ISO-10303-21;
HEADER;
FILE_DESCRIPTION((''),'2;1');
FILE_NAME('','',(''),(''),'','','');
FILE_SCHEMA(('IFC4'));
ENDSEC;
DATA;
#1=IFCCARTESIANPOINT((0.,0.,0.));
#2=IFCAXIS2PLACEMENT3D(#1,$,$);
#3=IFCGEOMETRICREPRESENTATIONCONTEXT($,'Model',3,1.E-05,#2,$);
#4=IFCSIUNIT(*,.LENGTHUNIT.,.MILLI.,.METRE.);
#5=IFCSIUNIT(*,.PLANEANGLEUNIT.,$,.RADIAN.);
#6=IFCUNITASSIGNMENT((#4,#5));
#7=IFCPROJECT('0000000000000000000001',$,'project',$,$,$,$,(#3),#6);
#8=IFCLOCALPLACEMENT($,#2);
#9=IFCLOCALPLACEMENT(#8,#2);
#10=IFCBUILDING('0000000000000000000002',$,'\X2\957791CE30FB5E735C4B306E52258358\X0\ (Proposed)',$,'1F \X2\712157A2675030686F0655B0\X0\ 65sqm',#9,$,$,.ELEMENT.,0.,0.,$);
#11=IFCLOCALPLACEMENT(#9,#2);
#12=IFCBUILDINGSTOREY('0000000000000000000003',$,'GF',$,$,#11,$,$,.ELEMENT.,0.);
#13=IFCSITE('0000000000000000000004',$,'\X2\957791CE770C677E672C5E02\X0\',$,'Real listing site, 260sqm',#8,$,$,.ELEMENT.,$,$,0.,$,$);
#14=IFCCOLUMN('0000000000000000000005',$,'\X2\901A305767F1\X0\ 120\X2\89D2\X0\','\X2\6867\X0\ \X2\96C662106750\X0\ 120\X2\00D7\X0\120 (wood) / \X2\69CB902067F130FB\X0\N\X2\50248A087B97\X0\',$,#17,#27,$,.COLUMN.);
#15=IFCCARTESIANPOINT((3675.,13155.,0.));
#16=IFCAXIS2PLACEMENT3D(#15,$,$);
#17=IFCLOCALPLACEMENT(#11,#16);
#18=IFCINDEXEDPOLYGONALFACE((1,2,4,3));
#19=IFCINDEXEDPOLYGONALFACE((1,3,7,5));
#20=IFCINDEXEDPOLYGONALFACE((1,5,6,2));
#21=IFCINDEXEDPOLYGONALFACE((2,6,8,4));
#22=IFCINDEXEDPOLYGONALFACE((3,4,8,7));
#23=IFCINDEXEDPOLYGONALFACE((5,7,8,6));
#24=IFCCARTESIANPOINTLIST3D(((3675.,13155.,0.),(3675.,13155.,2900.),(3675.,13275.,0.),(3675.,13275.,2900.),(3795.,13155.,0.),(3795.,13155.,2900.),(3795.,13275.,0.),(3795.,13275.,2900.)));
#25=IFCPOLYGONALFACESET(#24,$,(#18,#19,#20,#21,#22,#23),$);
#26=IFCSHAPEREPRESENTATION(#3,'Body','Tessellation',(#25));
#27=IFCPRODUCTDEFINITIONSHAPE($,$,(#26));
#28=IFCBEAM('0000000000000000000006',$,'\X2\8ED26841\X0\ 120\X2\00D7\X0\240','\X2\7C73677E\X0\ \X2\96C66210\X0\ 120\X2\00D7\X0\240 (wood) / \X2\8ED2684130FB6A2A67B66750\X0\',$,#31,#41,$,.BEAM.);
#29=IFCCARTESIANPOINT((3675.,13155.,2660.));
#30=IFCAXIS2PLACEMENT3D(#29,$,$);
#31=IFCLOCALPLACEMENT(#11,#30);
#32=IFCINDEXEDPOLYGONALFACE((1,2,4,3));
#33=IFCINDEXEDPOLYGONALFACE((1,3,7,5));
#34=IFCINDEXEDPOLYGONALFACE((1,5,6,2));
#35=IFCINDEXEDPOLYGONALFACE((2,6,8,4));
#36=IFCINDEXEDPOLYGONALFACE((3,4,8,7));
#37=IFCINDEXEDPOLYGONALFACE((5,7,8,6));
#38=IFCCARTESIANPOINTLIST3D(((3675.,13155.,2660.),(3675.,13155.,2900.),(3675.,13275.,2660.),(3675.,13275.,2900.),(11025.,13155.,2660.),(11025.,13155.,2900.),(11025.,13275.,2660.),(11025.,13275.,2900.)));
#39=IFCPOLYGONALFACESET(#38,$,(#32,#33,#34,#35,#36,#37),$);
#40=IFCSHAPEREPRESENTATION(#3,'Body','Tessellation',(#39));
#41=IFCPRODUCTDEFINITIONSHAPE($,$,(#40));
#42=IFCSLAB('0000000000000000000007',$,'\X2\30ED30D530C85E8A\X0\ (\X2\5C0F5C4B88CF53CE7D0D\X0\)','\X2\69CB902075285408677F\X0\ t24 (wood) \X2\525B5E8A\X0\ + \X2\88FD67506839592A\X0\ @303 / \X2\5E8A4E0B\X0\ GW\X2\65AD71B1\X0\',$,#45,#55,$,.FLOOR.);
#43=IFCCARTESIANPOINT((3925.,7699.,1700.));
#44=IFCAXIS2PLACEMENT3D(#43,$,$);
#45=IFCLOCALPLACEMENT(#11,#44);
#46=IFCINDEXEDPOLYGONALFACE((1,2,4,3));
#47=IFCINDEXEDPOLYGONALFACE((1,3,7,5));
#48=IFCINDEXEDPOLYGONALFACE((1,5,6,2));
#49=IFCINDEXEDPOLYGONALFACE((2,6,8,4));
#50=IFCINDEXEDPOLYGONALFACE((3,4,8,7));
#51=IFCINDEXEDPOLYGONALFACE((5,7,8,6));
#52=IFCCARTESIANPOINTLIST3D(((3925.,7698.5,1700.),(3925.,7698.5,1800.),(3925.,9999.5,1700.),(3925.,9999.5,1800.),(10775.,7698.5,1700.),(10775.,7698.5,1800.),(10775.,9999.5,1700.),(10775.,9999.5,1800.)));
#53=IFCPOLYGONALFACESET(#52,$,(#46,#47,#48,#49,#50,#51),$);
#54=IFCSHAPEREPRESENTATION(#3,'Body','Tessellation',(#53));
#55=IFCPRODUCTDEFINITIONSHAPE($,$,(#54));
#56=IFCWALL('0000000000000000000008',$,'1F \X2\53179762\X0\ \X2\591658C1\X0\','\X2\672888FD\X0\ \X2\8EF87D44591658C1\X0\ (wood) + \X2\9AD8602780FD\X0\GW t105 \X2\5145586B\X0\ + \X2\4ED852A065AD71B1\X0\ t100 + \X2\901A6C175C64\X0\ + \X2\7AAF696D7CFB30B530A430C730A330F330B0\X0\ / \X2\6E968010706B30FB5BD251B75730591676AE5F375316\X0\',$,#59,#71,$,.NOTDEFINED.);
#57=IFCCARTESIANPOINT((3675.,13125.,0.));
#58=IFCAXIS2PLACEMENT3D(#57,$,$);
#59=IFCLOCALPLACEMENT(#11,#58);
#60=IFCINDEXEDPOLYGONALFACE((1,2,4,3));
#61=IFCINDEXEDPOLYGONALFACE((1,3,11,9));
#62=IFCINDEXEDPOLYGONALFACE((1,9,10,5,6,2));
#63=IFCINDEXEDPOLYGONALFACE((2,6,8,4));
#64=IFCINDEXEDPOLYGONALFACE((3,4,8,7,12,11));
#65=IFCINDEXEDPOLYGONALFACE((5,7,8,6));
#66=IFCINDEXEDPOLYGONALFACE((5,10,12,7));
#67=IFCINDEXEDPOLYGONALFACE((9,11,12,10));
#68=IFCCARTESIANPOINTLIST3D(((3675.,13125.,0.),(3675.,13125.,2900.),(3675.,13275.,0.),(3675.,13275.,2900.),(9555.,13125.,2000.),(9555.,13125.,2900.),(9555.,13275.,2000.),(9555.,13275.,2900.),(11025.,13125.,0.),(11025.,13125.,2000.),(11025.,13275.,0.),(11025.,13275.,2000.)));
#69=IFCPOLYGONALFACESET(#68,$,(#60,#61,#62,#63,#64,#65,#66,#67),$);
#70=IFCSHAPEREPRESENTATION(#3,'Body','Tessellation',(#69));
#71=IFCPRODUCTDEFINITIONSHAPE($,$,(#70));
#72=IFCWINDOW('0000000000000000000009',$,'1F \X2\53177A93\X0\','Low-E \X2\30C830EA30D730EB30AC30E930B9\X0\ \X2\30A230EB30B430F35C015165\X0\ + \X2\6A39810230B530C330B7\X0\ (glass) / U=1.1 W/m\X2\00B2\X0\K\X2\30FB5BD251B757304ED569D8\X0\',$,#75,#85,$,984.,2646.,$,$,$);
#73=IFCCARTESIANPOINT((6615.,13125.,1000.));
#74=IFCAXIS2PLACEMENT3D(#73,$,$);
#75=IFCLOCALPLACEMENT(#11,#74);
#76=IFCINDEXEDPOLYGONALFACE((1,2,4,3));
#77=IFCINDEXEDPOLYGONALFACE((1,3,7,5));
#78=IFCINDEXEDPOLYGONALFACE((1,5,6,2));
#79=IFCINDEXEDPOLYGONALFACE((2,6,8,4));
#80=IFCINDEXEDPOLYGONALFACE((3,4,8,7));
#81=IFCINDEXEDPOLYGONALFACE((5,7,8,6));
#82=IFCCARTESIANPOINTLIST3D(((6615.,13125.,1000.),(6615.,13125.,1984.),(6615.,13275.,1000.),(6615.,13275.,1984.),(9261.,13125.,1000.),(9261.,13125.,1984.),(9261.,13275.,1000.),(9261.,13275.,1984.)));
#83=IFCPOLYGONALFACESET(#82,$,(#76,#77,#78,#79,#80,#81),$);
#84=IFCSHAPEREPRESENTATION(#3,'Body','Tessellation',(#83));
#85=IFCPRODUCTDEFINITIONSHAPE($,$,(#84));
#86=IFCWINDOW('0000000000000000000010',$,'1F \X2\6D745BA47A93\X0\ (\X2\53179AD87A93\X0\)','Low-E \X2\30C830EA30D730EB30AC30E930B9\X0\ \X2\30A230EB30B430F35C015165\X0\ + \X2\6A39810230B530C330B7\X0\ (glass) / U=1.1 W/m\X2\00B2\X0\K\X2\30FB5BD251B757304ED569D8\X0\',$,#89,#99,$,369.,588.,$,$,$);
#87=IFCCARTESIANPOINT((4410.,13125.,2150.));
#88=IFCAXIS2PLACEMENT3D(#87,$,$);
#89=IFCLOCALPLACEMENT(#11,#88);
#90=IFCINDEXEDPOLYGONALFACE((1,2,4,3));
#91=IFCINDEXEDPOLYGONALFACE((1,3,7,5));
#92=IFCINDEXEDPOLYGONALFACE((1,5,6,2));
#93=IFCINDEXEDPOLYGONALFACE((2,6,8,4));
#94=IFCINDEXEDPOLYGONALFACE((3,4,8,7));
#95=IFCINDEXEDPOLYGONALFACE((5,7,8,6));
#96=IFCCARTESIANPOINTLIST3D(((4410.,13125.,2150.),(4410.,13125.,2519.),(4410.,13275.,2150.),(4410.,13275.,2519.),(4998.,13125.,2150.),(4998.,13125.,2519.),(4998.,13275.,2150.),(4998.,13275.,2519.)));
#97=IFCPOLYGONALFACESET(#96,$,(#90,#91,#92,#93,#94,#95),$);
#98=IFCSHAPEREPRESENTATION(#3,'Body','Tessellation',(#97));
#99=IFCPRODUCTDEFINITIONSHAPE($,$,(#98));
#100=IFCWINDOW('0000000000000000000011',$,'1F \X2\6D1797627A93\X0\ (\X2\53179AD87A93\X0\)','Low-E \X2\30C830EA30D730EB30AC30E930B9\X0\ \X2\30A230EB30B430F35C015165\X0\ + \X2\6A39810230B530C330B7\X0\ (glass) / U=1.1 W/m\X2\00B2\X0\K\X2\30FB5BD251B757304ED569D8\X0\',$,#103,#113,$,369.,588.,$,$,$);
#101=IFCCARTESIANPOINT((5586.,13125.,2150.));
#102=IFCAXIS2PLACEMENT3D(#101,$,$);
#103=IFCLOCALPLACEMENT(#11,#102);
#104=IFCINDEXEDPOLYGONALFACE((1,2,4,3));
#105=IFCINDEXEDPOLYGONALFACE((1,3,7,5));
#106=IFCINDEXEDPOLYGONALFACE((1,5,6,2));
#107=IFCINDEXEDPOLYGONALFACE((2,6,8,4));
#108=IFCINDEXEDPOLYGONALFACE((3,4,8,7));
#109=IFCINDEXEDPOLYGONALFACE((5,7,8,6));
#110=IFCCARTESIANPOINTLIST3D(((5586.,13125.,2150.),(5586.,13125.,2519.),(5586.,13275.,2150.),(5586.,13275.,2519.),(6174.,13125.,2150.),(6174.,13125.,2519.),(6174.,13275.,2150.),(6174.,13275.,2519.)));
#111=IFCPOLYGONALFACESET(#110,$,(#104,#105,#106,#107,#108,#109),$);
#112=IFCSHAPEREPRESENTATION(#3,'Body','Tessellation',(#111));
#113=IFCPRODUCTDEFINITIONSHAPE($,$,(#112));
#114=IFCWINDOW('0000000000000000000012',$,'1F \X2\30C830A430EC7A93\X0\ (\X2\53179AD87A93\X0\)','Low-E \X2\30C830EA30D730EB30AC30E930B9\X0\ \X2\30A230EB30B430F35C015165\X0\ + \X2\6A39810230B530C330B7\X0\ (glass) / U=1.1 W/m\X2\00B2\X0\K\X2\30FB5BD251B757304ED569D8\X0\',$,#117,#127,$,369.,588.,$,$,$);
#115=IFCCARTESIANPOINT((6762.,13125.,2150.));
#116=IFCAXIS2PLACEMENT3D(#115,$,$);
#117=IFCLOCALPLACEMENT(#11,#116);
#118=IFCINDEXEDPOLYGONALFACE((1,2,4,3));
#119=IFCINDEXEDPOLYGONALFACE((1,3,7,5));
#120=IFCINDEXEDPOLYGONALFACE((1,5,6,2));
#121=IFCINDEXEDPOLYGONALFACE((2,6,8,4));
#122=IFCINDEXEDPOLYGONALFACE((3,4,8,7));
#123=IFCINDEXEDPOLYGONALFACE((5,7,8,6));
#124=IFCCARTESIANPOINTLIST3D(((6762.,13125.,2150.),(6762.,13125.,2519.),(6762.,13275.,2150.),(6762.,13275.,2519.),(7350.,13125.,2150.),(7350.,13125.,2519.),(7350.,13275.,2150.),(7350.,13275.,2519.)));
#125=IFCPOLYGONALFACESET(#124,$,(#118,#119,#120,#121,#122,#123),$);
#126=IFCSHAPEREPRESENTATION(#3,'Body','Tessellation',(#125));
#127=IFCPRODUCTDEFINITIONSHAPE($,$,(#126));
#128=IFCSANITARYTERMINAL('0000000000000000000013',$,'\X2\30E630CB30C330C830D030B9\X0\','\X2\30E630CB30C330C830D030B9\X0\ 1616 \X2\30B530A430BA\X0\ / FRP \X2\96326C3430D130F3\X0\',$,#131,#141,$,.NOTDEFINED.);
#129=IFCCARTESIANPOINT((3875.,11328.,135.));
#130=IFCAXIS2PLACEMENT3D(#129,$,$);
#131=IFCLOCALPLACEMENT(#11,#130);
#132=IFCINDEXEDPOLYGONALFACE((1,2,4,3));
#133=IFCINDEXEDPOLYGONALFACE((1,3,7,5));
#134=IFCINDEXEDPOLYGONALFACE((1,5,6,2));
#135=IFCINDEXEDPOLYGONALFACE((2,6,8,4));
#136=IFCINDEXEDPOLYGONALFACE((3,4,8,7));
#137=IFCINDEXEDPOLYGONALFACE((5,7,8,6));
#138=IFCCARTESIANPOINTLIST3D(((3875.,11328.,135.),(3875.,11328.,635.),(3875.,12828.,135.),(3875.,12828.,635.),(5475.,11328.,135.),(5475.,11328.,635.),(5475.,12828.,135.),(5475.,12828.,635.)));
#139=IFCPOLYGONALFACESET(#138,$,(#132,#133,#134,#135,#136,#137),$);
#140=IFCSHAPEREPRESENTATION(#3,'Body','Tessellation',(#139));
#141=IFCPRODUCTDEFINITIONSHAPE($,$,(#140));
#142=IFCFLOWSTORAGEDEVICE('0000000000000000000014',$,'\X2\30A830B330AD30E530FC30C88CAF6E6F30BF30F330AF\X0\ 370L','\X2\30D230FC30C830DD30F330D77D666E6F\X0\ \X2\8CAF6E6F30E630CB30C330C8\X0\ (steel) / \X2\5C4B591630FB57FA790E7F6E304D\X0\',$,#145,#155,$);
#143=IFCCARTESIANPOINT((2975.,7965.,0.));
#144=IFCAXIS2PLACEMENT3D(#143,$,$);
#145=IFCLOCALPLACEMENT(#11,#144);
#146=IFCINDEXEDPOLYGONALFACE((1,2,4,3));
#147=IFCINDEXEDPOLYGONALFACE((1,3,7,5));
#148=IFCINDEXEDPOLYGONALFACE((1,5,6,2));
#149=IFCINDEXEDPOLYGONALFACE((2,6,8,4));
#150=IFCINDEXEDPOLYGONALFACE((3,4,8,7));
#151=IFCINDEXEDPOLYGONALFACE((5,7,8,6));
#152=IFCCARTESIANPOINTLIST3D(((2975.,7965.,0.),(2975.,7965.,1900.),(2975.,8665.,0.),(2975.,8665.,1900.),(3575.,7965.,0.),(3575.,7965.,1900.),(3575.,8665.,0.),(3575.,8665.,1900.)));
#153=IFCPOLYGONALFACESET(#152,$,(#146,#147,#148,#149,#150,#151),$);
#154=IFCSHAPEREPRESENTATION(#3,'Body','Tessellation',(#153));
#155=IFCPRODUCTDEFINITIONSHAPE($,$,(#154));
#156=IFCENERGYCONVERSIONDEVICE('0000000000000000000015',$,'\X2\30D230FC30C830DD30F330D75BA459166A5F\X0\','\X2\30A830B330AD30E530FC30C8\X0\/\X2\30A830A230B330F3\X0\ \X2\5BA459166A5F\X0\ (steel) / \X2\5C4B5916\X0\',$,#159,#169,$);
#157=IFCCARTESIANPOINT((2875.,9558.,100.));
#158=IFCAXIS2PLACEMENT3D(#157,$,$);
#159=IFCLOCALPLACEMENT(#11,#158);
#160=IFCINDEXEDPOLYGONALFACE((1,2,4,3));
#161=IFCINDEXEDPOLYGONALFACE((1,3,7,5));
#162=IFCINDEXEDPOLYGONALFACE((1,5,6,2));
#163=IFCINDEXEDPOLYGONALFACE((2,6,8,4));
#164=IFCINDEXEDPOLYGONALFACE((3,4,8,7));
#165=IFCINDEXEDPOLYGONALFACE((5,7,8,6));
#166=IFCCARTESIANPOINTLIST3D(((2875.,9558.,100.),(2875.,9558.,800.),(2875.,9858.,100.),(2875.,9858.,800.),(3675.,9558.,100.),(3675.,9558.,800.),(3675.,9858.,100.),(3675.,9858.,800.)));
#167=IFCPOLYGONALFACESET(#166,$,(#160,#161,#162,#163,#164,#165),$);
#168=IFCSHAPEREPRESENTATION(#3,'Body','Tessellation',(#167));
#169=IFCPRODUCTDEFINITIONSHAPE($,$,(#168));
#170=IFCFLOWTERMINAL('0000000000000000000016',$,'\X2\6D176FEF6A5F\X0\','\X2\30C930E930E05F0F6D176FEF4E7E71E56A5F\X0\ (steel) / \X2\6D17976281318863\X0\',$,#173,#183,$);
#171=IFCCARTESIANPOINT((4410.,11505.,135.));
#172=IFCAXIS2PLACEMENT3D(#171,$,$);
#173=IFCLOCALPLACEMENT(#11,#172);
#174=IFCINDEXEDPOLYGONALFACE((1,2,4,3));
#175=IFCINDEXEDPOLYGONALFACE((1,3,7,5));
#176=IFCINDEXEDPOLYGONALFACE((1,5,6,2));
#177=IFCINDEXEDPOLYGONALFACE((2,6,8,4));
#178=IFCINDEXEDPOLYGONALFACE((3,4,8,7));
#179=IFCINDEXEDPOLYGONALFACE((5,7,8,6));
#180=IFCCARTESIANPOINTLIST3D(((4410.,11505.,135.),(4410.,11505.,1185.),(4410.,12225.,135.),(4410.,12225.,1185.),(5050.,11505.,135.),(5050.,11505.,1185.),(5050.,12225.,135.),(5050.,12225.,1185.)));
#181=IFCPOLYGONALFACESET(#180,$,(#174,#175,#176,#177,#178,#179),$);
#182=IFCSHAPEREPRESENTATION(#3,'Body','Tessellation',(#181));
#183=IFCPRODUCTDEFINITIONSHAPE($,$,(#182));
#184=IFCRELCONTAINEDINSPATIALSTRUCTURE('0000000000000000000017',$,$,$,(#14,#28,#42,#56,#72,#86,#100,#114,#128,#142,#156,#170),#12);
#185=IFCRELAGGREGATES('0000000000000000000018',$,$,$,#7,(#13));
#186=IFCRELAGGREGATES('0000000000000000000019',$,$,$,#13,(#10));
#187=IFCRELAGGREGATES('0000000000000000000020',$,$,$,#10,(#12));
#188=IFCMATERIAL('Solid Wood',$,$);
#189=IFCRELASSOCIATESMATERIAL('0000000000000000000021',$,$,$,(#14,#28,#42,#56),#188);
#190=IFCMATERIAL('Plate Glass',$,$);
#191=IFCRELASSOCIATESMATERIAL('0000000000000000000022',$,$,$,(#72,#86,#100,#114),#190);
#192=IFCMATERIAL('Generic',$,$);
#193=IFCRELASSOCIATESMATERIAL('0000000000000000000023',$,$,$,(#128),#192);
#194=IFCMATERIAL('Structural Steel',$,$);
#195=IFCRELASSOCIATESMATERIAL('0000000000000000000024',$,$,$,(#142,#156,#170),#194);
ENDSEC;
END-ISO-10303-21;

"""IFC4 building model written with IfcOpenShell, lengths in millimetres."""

from ifc_helpers import new_model, si_unit, frame, frame_2d, origin, place, context, project, spatial, rectangle, extrude, material, element, fill, save


model = new_model("IFC4")

# Units and contexts
model_context = context("Model", 3, precision=1e-05, world=origin())
ifc_project = project(units=[si_unit("LENGTHUNIT", "METRE", prefix="MILLI"), si_unit("PLANEANGLEUNIT", "RADIAN")], contexts=[model_context])

# Site, building, storey
site_placement = place(None, origin())
site = spatial("IfcSite", under=ifc_project, at=site_placement, Name="長野県松本市", ObjectType="Real listing site, 260sqm", CompositionType="ELEMENT", RefElevation=0.0)
building_placement = place(site_placement, origin())
building = spatial("IfcBuilding", under=site, at=building_placement, Name="長野・平屋の別荘 (Proposed)", ObjectType="1F 無垢材と漆喰 65sqm", CompositionType="ELEMENT", ElevationOfRefHeight=0.0, ElevationOfTerrain=0.0)
storey_placement = place(building_placement, origin())
storey = spatial("IfcBuildingStorey", under=building, at=storey_placement, Name="GF", CompositionType="ELEMENT", Elevation=0.0)

# Column
ifc_material_1 = material(Name="Solid Wood")
column_1_placement = place(storey_placement, frame((3675.0, 13155.0, 0.0)))
element("IfcColumn", 1, at=column_1_placement, inside=storey, material=ifc_material_1, Name="通し柱 120角", Description="桧 集成材 120×120 (wood) / 構造柱・N値計算", PredefinedType="COLUMN", context=model_context, shape_type="SweptSolid", body=[
    extrude(rectangle(XDim=120.0, YDim=120.0, at=frame_2d((60.0, 60.0))), frame((3675.0, 13155.0, 0.0)), (0.0, 0.0, 1.0), 2900.0),
])

# Beam
beam_1_placement = place(storey_placement, frame((3675.0, 13155.0, 2660.0)))
element("IfcBeam", 2, at=beam_1_placement, inside=storey, material=ifc_material_1, Name="軒桁 120×240", Description="米松 集成 120×240 (wood) / 軒桁・横架材", PredefinedType="BEAM", context=model_context, shape_type="SweptSolid", body=[
    extrude(rectangle(XDim=7350.0, YDim=120.0, at=frame_2d((3675.0, 60.0))), frame((3675.0, 13155.0, 2660.0)), (0.0, 0.0, 1.0), 240.0),
])

# Slab
slab_placement = place(storey_placement, frame((3925.0, 7699.0, 1700.0)))
element("IfcSlab", 3, at=slab_placement, inside=storey, material=ifc_material_1, Name="ロフト床 (小屋裏収納)", Description="構造用合板 t24 (wood) 剛床 + 製材根太 @303 / 床下 GW断熱", PredefinedType="FLOOR", context=model_context, shape_type="SweptSolid", body=[
    extrude(rectangle(XDim=6850.0, YDim=2301.0, at=frame_2d((3425.0, 1150.0))), frame((3925.0, 7699.0, 1700.0)), (0.0, 0.0, 1.0), 100.0),
])

# Wall, openings, windows
wall_1_placement = place(storey_placement, frame((3675.0, 13125.0, 0.0)))
wall_1 = element("IfcWall", 4, at=wall_1_placement, inside=storey, material=ifc_material_1, Name="1F 北面 外壁", Description="木製 軸組外壁 (wood) + 高性能GW t105 充填 + 付加断熱 t100 + 通気層 + 窯業系サイディング / 準耐火・寒冷地外皮強化", PredefinedType="NOTDEFINED", context=model_context, shape_type="SweptSolid", body=[
    extrude(rectangle(XDim=7350.0, YDim=150.0, at=frame_2d((3675.0, 75.0))), frame((3675.0, 13125.0, 0.0)), (0.0, 0.0, 1.0), 2900.0),
])
opening_1_placement = place(storey_placement, frame((6615.0, 13125.0, 1000.0)))
opening_1 = element("IfcOpeningElement", 5, at=opening_1_placement, cuts=wall_1, PredefinedType="NOTDEFINED", context=model_context, shape_type="SweptSolid", body=[
    extrude(rectangle(XDim=2646.0, YDim=150.0, at=frame_2d((1323.0, 75.0))), frame((6615.0, 13125.0, 1000.0)), (0.0, 0.0, 1.0), 984.0),
])
opening_2_placement = place(storey_placement, frame((4410.0, 13125.0, 2150.0)))
opening_2 = element("IfcOpeningElement", 6, at=opening_2_placement, cuts=wall_1, PredefinedType="NOTDEFINED", context=model_context, shape_type="SweptSolid", body=[
    extrude(rectangle(XDim=588.0, YDim=150.0, at=frame_2d((294.0, 75.0))), frame((4410.0, 13125.0, 2150.0)), (0.0, 0.0, 1.0), 369.0),
])
opening_3_placement = place(storey_placement, frame((5586.0, 13125.0, 2150.0)))
opening_3 = element("IfcOpeningElement", 7, at=opening_3_placement, cuts=wall_1, PredefinedType="NOTDEFINED", context=model_context, shape_type="SweptSolid", body=[
    extrude(rectangle(XDim=588.0, YDim=150.0, at=frame_2d((294.0, 75.0))), frame((5586.0, 13125.0, 2150.0)), (0.0, 0.0, 1.0), 369.0),
])
opening_4_placement = place(storey_placement, frame((6762.0, 13125.0, 2150.0)))
opening_4 = element("IfcOpeningElement", 8, at=opening_4_placement, cuts=wall_1, PredefinedType="NOTDEFINED", context=model_context, shape_type="SweptSolid", body=[
    extrude(rectangle(XDim=588.0, YDim=150.0, at=frame_2d((294.0, 75.0))), frame((6762.0, 13125.0, 2150.0)), (0.0, 0.0, 1.0), 369.0),
])
ifc_material_2 = material(Name="Plate Glass")
window_1_placement = place(storey_placement, frame((6615.0, 13125.0, 1000.0)))
window_1 = element("IfcWindow", 9, at=window_1_placement, inside=storey, material=ifc_material_2, Name="1F 北窓", Description="Low-E トリプルガラス アルゴン封入 + 樹脂サッシ (glass) / U=1.1 W/m²K・寒冷地仕様", OverallHeight=984.0, OverallWidth=2646.0, context=model_context, shape_type="SweptSolid", body=[
    extrude(rectangle(XDim=2646.0, YDim=150.0, at=frame_2d((1323.0, 75.0))), frame((6615.0, 13125.0, 1000.0)), (0.0, 0.0, 1.0), 984.0),
])
fill(opening_1, window_1)
window_2_placement = place(storey_placement, frame((4410.0, 13125.0, 2150.0)))
window_2 = element("IfcWindow", 10, at=window_2_placement, inside=storey, material=ifc_material_2, Name="1F 浴室窓 (北高窓)", Description="Low-E トリプルガラス アルゴン封入 + 樹脂サッシ (glass) / U=1.1 W/m²K・寒冷地仕様", OverallHeight=369.0, OverallWidth=588.0, context=model_context, shape_type="SweptSolid", body=[
    extrude(rectangle(XDim=588.0, YDim=150.0, at=frame_2d((294.0, 75.0))), frame((4410.0, 13125.0, 2150.0)), (0.0, 0.0, 1.0), 369.0),
])
fill(opening_2, window_2)
window_3_placement = place(storey_placement, frame((5586.0, 13125.0, 2150.0)))
window_3 = element("IfcWindow", 11, at=window_3_placement, inside=storey, material=ifc_material_2, Name="1F 洗面窓 (北高窓)", Description="Low-E トリプルガラス アルゴン封入 + 樹脂サッシ (glass) / U=1.1 W/m²K・寒冷地仕様", OverallHeight=369.0, OverallWidth=588.0, context=model_context, shape_type="SweptSolid", body=[
    extrude(rectangle(XDim=588.0, YDim=150.0, at=frame_2d((294.0, 75.0))), frame((5586.0, 13125.0, 2150.0)), (0.0, 0.0, 1.0), 369.0),
])
fill(opening_3, window_3)
window_4_placement = place(storey_placement, frame((6762.0, 13125.0, 2150.0)))
window_4 = element("IfcWindow", 12, at=window_4_placement, inside=storey, material=ifc_material_2, Name="1F トイレ窓 (北高窓)", Description="Low-E トリプルガラス アルゴン封入 + 樹脂サッシ (glass) / U=1.1 W/m²K・寒冷地仕様", OverallHeight=369.0, OverallWidth=588.0, context=model_context, shape_type="SweptSolid", body=[
    extrude(rectangle(XDim=588.0, YDim=150.0, at=frame_2d((294.0, 75.0))), frame((6762.0, 13125.0, 2150.0)), (0.0, 0.0, 1.0), 369.0),
])
fill(opening_4, window_4)

# Sanitary terminal
ifc_material_3 = material(Name="Generic")
sanitary_terminal_placement = place(storey_placement, frame((3875.0, 11328.0, 135.0)))
element("IfcSanitaryTerminal", 13, at=sanitary_terminal_placement, inside=storey, material=ifc_material_3, Name="ユニットバス", Description="ユニットバス 1616 サイズ / FRP 防水パン", PredefinedType="NOTDEFINED", context=model_context, shape_type="SweptSolid", body=[
    extrude(rectangle(XDim=1600.0, YDim=1500.0, at=frame_2d((800.0, 750.0))), frame((3875.0, 11328.0, 135.0)), (0.0, 0.0, 1.0), 500.0),
])

# Flow storage device
ifc_material_4 = material(Name="Structural Steel")
flow_storage_device_placement = place(storey_placement, frame((2975.0, 7965.0, 0.0)))
element("IfcFlowStorageDevice", 14, at=flow_storage_device_placement, inside=storey, material=ifc_material_4, Name="エコキュート貯湯タンク 370L", Description="ヒートポンプ給湯 貯湯ユニット (steel) / 屋外・基礎置き", context=model_context, shape_type="SweptSolid", body=[
    extrude(rectangle(XDim=600.0, YDim=700.0, at=frame_2d((300.0, 350.0))), frame((2975.0, 7965.0, 0.0)), (0.0, 0.0, 1.0), 1900.0),
])

# Energy conversion device
energy_conversion_device_placement = place(storey_placement, frame((2875.0, 9558.0, 100.0)))
element("IfcEnergyConversionDevice", 15, at=energy_conversion_device_placement, inside=storey, material=ifc_material_4, Name="ヒートポンプ室外機", Description="エコキュート/エアコン 室外機 (steel) / 屋外", context=model_context, shape_type="SweptSolid", body=[
    extrude(rectangle(XDim=800.0, YDim=300.0, at=frame_2d((400.0, 150.0))), frame((2875.0, 9558.0, 100.0)), (0.0, 0.0, 1.0), 700.0),
])

# Flow terminal
flow_terminal_placement = place(storey_placement, frame((4410.0, 11505.0, 135.0)))
element("IfcFlowTerminal", 16, at=flow_terminal_placement, inside=storey, material=ifc_material_4, Name="洗濯機", Description="ドラム式洗濯乾燥機 (steel) / 洗面脱衣", context=model_context, shape_type="SweptSolid", body=[
    extrude(rectangle(XDim=640.0, YDim=720.0, at=frame_2d((320.0, 360.0))), frame((4410.0, 11505.0, 135.0)), (0.0, 0.0, 1.0), 1050.0),
])

save(model, "model.ifc")
